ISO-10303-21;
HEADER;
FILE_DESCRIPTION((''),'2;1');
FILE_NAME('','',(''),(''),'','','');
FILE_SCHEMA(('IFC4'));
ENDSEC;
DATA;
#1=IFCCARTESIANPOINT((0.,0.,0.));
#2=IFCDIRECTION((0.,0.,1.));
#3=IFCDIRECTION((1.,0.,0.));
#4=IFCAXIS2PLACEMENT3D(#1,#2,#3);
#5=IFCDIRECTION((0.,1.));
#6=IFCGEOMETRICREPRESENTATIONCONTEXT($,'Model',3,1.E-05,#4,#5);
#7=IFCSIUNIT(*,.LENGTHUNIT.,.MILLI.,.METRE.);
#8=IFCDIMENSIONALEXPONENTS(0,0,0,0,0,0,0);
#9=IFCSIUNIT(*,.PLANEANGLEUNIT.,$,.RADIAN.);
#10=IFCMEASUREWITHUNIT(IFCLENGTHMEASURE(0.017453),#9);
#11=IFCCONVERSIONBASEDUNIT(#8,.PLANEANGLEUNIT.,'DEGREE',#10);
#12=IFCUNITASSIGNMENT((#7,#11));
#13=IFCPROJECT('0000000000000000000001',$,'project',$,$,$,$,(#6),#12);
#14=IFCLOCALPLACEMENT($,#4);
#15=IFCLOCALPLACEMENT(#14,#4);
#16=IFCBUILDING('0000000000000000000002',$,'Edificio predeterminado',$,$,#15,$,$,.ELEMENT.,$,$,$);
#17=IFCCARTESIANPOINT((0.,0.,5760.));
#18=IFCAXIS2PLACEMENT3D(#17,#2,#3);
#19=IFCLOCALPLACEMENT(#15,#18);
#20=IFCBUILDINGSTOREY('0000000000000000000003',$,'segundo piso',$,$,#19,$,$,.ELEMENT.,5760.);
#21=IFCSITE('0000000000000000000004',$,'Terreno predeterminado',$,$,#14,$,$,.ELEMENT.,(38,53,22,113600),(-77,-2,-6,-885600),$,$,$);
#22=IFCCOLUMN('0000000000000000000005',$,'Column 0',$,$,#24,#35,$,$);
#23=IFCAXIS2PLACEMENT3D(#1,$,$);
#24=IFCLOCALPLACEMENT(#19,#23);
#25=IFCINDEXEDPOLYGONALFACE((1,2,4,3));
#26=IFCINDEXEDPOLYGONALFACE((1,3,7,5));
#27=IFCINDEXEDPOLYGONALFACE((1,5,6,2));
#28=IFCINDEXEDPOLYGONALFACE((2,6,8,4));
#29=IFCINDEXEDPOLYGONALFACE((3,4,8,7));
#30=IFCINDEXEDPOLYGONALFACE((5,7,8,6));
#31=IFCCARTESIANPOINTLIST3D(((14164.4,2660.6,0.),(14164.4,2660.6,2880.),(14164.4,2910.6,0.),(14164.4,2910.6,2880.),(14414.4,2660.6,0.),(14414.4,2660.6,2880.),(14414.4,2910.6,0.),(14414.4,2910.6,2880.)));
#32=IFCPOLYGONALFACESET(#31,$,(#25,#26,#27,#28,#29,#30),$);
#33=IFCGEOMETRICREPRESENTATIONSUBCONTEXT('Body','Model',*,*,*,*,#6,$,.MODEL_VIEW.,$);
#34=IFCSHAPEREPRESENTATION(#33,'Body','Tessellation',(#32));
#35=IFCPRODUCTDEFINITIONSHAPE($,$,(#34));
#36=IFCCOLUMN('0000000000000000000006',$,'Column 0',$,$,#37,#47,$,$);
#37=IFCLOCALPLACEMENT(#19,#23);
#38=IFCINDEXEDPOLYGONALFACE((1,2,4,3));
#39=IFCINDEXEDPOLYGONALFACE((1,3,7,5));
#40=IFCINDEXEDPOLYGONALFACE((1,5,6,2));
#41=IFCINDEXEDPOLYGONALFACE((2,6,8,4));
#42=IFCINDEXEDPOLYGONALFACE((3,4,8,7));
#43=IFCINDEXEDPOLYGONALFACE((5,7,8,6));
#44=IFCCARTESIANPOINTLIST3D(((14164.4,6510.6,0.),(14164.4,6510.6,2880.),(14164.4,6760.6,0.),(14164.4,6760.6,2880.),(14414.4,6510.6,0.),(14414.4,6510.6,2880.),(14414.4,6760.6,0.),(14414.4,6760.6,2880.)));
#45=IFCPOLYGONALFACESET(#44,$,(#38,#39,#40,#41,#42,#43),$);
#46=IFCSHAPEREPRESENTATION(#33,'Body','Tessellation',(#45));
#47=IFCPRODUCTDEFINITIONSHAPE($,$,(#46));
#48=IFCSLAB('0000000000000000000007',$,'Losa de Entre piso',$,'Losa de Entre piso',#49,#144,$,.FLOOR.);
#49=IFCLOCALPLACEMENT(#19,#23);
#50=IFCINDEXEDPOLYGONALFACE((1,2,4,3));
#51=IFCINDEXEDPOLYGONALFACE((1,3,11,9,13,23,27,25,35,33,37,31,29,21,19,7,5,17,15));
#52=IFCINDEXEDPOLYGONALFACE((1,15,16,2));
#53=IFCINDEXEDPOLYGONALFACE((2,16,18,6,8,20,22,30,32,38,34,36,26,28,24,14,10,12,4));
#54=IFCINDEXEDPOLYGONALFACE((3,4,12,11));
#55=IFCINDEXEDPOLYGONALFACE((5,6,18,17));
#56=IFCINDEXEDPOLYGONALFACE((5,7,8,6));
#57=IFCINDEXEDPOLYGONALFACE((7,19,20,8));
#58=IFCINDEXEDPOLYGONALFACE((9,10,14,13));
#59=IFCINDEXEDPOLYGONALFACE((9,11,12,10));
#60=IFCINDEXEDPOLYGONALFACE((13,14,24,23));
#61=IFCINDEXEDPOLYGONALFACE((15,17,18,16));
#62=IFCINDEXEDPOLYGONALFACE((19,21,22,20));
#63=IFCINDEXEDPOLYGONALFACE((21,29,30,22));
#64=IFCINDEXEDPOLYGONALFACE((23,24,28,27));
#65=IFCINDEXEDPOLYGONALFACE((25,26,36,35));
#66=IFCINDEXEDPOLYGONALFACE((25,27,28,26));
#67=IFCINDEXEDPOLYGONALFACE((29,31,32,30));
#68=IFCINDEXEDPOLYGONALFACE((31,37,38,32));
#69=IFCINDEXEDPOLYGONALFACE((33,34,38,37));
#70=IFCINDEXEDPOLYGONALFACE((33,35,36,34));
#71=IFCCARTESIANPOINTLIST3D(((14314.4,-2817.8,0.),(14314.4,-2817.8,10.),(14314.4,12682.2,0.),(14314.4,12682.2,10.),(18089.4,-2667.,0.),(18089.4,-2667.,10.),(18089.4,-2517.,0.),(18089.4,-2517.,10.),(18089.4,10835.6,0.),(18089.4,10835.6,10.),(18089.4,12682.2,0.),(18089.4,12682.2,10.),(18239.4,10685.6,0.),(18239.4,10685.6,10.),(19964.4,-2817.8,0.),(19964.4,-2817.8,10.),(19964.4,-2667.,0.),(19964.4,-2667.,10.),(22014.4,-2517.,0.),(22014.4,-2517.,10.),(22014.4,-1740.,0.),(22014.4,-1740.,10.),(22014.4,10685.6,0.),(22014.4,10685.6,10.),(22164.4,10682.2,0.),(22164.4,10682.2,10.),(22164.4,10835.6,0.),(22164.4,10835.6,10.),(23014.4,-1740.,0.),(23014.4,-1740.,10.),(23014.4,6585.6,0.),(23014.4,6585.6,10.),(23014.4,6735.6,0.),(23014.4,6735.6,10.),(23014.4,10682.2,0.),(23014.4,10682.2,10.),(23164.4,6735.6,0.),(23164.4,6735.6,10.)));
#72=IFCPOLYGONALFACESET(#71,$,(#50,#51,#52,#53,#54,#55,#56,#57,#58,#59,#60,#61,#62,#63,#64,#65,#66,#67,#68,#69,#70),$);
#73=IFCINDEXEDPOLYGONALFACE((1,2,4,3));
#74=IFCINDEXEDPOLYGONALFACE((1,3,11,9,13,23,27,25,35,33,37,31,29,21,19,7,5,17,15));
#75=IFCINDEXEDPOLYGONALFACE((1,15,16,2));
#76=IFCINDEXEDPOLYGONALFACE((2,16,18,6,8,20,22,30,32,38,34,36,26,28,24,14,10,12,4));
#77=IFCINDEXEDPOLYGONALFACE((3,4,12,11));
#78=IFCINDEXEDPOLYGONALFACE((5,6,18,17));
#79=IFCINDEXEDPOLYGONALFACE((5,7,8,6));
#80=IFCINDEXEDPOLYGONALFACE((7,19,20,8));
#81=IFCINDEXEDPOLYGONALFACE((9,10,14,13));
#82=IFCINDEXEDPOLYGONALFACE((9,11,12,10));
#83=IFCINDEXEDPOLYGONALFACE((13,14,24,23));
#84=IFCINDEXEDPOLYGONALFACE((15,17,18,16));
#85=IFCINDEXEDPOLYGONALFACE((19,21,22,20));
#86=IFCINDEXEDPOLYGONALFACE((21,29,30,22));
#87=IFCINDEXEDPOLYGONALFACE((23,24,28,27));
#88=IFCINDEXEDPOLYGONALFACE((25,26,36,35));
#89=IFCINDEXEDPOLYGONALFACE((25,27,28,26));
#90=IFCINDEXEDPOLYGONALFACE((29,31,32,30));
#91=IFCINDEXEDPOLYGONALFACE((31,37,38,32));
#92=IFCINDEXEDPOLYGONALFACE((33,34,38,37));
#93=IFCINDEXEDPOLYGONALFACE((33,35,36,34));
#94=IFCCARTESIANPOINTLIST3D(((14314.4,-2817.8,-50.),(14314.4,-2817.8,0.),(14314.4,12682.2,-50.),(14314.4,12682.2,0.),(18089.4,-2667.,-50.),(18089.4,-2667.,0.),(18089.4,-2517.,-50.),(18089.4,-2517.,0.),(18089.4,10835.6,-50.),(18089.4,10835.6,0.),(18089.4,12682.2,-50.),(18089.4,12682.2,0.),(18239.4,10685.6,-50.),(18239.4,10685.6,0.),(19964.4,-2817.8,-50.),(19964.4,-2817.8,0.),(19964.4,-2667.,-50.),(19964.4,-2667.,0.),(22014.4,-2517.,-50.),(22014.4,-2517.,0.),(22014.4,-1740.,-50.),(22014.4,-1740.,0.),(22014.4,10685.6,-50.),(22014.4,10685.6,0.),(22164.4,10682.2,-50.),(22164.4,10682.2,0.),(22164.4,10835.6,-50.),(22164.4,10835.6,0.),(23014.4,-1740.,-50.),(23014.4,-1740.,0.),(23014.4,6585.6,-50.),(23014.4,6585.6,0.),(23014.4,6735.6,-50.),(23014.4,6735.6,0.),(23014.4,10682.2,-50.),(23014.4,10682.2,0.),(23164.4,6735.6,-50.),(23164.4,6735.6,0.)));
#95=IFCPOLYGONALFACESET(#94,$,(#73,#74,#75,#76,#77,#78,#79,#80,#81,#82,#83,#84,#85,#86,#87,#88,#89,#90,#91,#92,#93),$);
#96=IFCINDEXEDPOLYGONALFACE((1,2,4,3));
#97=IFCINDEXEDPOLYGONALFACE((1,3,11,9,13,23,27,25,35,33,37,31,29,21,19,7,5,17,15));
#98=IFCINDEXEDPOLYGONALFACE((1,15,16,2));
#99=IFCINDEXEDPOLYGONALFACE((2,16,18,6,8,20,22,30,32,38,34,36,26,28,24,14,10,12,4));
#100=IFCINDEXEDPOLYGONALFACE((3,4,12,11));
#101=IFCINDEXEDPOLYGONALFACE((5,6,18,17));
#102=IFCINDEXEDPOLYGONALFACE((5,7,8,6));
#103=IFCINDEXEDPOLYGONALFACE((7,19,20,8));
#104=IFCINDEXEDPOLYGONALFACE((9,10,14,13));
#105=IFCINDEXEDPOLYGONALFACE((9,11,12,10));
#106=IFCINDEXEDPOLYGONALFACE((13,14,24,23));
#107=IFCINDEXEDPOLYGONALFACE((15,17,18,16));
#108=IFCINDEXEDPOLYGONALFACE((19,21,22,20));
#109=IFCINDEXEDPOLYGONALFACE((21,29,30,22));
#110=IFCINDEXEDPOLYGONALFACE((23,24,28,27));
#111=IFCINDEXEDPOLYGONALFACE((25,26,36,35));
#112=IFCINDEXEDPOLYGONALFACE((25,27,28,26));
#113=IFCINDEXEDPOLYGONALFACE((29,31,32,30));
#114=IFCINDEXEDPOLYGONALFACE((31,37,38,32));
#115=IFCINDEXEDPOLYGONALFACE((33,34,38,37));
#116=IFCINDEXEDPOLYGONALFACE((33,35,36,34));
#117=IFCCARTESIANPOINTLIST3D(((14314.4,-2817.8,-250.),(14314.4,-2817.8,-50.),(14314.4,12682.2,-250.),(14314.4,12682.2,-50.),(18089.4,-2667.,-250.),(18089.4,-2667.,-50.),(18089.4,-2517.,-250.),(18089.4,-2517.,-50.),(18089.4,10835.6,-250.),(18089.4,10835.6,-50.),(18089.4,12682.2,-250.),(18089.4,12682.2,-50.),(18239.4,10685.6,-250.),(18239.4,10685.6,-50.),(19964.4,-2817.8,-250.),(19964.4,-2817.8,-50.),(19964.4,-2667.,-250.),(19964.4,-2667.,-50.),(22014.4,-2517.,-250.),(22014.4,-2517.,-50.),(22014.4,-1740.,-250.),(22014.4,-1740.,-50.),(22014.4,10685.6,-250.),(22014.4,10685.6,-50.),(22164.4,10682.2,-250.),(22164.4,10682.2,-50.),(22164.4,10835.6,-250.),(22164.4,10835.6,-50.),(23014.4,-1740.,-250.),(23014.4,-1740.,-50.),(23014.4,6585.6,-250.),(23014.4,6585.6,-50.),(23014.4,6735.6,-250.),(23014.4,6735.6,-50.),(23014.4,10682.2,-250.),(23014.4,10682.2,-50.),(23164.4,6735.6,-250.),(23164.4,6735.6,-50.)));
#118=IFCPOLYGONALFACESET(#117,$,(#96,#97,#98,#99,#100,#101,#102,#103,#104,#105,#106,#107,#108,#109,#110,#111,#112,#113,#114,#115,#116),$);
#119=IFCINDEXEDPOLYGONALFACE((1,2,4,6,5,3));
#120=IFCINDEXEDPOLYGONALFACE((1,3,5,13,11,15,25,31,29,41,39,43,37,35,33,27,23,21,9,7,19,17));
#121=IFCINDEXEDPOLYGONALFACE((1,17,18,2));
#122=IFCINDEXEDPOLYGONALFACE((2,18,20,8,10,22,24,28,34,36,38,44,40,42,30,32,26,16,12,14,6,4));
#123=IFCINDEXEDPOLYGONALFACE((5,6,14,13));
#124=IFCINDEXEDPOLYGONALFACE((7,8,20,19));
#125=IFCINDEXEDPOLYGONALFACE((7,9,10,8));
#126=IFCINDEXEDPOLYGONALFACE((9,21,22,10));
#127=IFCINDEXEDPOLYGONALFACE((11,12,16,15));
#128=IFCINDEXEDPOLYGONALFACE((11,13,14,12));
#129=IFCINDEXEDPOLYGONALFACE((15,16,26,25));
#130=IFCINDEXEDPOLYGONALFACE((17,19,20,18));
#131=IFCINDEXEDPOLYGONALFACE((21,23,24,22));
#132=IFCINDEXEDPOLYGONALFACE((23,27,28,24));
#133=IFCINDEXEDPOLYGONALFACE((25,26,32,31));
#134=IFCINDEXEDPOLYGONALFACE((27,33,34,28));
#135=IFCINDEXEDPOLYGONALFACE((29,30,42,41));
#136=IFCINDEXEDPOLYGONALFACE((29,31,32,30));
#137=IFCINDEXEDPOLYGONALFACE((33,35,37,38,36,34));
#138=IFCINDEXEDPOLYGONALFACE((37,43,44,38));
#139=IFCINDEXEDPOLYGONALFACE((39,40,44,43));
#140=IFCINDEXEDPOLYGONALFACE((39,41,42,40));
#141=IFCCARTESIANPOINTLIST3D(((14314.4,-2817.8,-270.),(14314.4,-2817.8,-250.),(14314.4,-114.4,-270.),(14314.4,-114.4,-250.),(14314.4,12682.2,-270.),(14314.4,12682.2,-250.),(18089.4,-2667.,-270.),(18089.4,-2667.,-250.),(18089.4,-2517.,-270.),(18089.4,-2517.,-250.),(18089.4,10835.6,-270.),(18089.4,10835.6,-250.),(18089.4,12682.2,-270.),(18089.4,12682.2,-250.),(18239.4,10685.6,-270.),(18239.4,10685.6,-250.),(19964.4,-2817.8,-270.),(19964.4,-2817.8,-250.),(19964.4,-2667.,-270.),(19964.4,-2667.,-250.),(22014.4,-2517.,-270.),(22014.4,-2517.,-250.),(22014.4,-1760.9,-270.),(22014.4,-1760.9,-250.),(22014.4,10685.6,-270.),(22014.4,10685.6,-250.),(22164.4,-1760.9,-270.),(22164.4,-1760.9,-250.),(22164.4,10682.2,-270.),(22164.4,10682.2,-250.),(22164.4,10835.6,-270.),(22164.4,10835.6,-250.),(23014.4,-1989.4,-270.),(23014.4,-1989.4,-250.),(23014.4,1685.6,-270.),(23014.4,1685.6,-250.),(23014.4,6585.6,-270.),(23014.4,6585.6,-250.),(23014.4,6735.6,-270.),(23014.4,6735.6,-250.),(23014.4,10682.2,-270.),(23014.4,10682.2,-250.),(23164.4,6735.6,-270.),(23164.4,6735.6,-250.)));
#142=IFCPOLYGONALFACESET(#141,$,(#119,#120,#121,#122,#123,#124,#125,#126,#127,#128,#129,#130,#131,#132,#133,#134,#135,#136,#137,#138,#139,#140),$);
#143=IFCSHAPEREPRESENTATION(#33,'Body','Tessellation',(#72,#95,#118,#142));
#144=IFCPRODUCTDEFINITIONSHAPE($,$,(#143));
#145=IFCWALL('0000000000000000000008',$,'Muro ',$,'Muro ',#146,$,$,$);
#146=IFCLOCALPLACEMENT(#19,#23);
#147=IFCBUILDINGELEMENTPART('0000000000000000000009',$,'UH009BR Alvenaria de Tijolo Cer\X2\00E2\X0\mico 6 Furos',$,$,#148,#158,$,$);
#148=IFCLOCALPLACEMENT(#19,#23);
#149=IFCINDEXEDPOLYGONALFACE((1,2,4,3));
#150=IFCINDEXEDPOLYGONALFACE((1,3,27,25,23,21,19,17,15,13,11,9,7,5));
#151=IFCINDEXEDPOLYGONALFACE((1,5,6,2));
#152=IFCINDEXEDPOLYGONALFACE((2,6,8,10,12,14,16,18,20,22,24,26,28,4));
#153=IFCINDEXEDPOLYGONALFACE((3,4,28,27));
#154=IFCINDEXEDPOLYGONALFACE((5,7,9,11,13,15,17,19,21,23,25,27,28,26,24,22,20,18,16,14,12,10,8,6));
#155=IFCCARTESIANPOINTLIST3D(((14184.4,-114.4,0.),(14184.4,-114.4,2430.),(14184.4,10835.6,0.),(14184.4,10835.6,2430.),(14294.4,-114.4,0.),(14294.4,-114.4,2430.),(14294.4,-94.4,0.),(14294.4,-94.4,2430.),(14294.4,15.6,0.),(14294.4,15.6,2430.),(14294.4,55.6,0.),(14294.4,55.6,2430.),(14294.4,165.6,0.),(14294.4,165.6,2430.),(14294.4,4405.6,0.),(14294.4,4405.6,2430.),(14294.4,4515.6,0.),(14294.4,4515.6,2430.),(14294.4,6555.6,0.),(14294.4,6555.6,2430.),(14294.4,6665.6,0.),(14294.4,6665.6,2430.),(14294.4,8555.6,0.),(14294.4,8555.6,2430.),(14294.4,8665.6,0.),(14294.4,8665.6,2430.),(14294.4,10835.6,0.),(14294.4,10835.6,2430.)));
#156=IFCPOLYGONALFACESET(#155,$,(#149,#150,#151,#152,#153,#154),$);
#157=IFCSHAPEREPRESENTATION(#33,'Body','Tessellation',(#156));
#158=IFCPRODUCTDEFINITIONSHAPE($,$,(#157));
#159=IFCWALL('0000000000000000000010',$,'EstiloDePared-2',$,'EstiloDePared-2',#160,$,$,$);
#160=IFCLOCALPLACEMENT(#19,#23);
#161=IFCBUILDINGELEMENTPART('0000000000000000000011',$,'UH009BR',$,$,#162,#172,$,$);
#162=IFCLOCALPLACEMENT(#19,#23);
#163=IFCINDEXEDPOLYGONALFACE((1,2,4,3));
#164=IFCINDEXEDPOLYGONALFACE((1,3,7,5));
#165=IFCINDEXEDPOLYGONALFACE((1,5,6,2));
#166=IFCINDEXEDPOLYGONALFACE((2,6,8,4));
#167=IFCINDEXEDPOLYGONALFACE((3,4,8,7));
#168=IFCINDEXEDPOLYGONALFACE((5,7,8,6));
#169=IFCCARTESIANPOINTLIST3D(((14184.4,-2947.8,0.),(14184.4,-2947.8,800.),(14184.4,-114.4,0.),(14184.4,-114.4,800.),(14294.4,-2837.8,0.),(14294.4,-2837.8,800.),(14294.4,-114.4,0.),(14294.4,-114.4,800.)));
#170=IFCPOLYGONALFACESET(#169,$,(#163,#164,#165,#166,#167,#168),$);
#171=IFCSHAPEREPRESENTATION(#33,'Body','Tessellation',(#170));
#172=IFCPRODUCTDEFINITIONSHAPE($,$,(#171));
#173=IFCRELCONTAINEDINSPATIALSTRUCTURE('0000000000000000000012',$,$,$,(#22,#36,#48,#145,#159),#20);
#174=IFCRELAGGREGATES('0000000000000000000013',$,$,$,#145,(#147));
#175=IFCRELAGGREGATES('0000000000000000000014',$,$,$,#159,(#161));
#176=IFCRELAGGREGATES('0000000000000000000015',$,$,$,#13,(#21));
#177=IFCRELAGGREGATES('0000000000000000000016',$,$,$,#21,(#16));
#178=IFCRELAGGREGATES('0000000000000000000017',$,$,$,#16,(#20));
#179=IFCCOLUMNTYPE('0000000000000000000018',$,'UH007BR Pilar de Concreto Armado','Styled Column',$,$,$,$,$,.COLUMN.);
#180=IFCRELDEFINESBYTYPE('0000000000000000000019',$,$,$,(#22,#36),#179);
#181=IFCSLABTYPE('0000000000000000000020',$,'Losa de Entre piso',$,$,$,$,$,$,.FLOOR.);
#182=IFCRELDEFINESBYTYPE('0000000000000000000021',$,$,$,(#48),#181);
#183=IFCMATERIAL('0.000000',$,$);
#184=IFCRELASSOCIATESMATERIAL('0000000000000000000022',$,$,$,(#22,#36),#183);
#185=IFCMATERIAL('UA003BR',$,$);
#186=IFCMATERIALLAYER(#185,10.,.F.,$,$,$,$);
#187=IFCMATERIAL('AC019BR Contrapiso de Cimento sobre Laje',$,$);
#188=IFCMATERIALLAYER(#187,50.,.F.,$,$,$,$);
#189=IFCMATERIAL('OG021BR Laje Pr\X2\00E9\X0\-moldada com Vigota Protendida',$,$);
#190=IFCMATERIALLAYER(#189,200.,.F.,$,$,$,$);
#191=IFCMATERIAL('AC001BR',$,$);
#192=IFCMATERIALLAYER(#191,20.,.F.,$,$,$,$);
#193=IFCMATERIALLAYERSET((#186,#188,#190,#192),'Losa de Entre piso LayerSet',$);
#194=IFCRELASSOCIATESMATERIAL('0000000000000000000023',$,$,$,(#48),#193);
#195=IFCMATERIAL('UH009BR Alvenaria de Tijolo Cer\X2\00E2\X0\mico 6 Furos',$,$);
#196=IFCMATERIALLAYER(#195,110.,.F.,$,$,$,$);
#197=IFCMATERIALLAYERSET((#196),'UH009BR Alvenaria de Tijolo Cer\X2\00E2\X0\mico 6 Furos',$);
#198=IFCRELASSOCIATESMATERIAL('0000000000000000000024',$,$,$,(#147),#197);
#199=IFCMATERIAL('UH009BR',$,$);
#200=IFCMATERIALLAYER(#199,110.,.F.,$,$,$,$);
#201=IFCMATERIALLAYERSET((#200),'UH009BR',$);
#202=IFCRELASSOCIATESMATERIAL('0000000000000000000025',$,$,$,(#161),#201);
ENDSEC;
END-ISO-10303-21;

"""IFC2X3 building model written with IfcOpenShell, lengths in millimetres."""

from ifc_helpers import new_model, entity, si_unit, converted_unit, direction, frame, origin_with_axes, place, context, subcontext, project, spatial, polyline, outline, extrude, material, layer, layer_set, layer_usage, type_object, element, aggregate, save


model = new_model("IFC2X3")

# Units and contexts
model_context = context("Model", 3, precision=1e-05, world=origin_with_axes(), true_north=direction((0.0, 1.0)))
body_context = subcontext(model_context, "Body", "Model", "MODEL_VIEW")
ifc_project = project(units=[si_unit("LENGTHUNIT", "METRE", prefix="MILLI"), converted_unit("PLANEANGLEUNIT", "DEGREE", entity("IfcLengthMeasure", 0.017453), si_unit("PLANEANGLEUNIT", "RADIAN"), dimensions=[0, 0, 0, 0, 0, 0, 0])], contexts=[model_context])

# Site, building, storey
site_placement = place(None, origin_with_axes())
site = spatial("IfcSite", under=ifc_project, at=site_placement, Name="Terreno predeterminado", CompositionType="ELEMENT", RefLatitude=(38, 53, 22, 113600), RefLongitude=(-77, -2, -6, -885600))
building_placement = place(site_placement, origin_with_axes())
building = spatial("IfcBuilding", under=site, at=building_placement, Name="Edificio predeterminado", CompositionType="ELEMENT")
storey_placement = place(building_placement, frame((0.0, 0.0, 5760.0), z_axis=(0.0, 0.0, 1.0), x_axis=(1.0, 0.0, 0.0)))
storey = spatial("IfcBuildingStorey", under=building, at=storey_placement, Name="segundo piso", CompositionType="ELEMENT", Elevation=5760.0)

# Columns
ifc_material_1 = material(Name="0.000000")
column_type = type_object("IfcColumnType", Name="UH007BR Pilar de Concreto Armado", Description="Styled Column", PredefinedType="COLUMN")
for number, where, z_axis, x_axis, name in (
    (1, (14289.4, 2785.6, 0.0), (0.0, 0.0, 1.0), (1.0, 0.0, 0.0), "Column 0"),
    (2, (14289.4, 6635.6, 0.0), (0.0, 0.0, 1.0), (1.0, 0.0, 0.0), "Column 0"),
):
    element("IfcColumn", number, at=place(storey_placement, frame(where, z_axis=z_axis, x_axis=x_axis)), inside=storey, type_object=column_type, material=ifc_material_1, Name=name, context=body_context, shape_type="SweptSolid", body=[
        extrude(outline(polyline([(-125.0, -125.0), (125.0, -125.0), (125.0, 125.0), (-125.0, 125.0), (-125.0, -125.0)])), origin_with_axes(), (0.0, 0.0, 1.0), 2880.0),
    ])

# Slab
ifc_material_2 = material(Name="UA003BR")
ifc_layer_1 = layer(ifc_material_2, 10.0, ventilated=False)
ifc_material_3 = material(Name="AC019BR Contrapiso de Cimento sobre Laje")
ifc_layer_2 = layer(ifc_material_3, 50.0, ventilated=False)
ifc_material_4 = material(Name="OG021BR Laje Pré-moldada com Vigota Protendida")
ifc_layer_3 = layer(ifc_material_4, 200.0, ventilated=False)
ifc_material_5 = material(Name="AC001BR")
ifc_layer_4 = layer(ifc_material_5, 20.0, ventilated=False)
ifc_layer_set_1 = layer_set([ifc_layer_1, ifc_layer_2, ifc_layer_3, ifc_layer_4], Name="Losa de Entre piso LayerSet")
ifc_layer_usage_1 = layer_usage(ifc_layer_set_1, "AXIS3", "POSITIVE", 0.0)
slab_type = type_object("IfcSlabType", Name="Losa de Entre piso", PredefinedType="FLOOR")
slab_placement = place(storey_placement, frame((0.0, 0.0, -5760.0), z_axis=(0.0, 0.0, 1.0), x_axis=(1.0, 0.0, 0.0)))
element("IfcSlab", 3, at=slab_placement, inside=storey, type_object=slab_type, material=ifc_layer_usage_1, Name="Losa de Entre piso", ObjectType="Losa de Entre piso", PredefinedType="FLOOR", context=body_context, shape_type="SweptSolid", body=[
    extrude(outline(polyline([(0.0, -777.0), (-1000.0, -777.0), (-1000.0, -9102.6), (-1150.0, -9252.6), (-1000.0, -9252.6), (-1000.0, -13199.1), (-150.0, -13199.1), (-150.0, -13352.6), (0.0, -13202.6), (3775.0, -13202.6), (3925.0, -13352.6), (3925.0, -15199.1), (7700.0, -15199.1), (7700.0, 300.9), (2050.0, 300.9), (2050.0, 150.0), (3925.0, 150.0), (3925.0, 0.0), (0.0, 0.0), (0.0, -777.0)])), frame((22014.4, -2517.0, 5760.0), z_axis=(0.0, 0.0, 1.0), x_axis=(-1.0, 0.0, 0.0)), (0.0, 0.0, 1.0), 10.0),
    extrude(outline(polyline([(0.0, -777.0), (-1000.0, -777.0), (-1000.0, -9102.6), (-1150.0, -9252.6), (-1000.0, -9252.6), (-1000.0, -13199.1), (-150.0, -13199.1), (-150.0, -13352.6), (0.0, -13202.6), (3775.0, -13202.6), (3925.0, -13352.6), (3925.0, -15199.1), (7700.0, -15199.1), (7700.0, 300.9), (2050.0, 300.9), (2050.0, 150.0), (3925.0, 150.0), (3925.0, 0.0), (0.0, 0.0), (0.0, -777.0)])), frame((22014.4, -2517.0, 5710.0), z_axis=(0.0, 0.0, 1.0), x_axis=(-1.0, 0.0, 0.0)), (0.0, 0.0, 1.0), 50.0),
    extrude(outline(polyline([(0.0, -777.0), (-1000.0, -777.0), (-1000.0, -9102.6), (-1150.0, -9252.6), (-1000.0, -9252.6), (-1000.0, -13199.1), (-150.0, -13199.1), (-150.0, -13352.6), (0.0, -13202.6), (3775.0, -13202.6), (3925.0, -13352.6), (3925.0, -15199.1), (7700.0, -15199.1), (7700.0, 300.9), (2050.0, 300.9), (2050.0, 150.0), (3925.0, 150.0), (3925.0, 0.0), (0.0, 0.0), (0.0, -777.0)])), frame((22014.4, -2517.0, 5510.0), z_axis=(0.0, 0.0, 1.0), x_axis=(-1.0, 0.0, 0.0)), (0.0, 0.0, 1.0), 200.0),
    extrude(outline(polyline([(-1305.7, 1305.7), (-3975.1, -1363.6), (5073.5, -10412.1), (6985.1, -12323.8), (10980.3, -8328.6), (10873.6, -8221.9), (9547.8, -9547.8), (9441.7, -9441.7), (12217.1, -6666.3), (11682.5, -6131.7), (11788.6, -6025.7), (12551.1, -5586.1), (9952.5, -2987.5), (6487.7, 477.3), (6487.7, 689.4), (6381.6, 583.4), (3591.0, 3374.0), (2990.0, 2773.0), (2881.5, 2881.5), (2881.5, 2669.3), (212.1, 0.0), (0.0, 0.0), (-1305.7, 1305.7)])), frame((18089.4, 10835.6, 5490.0), z_axis=(0.0, 0.0, 1.0), x_axis=(0.707107, -0.707107, 0.0)), (0.0, 0.0, 1.0), 20.0),
])

# Walls, building element parts
wall_1_placement = place(storey_placement, frame((14239.4, 10835.6, 0.0), z_axis=(0.0, 0.0, 1.0), x_axis=(0.0, -1.0, 0.0)))
wall_1 = element("IfcWall", 4, at=wall_1_placement, inside=storey, Name="Muro ", ObjectType="Muro ")
ifc_material_6 = material(Name="UH009BR Alvenaria de Tijolo Cerâmico 6 Furos")
ifc_layer_5 = layer(ifc_material_6, 110.0, ventilated=False)
ifc_layer_set_2 = layer_set([ifc_layer_5], Name="UH009BR Alvenaria de Tijolo Cerâmico 6 Furos")
ifc_layer_usage_2 = layer_usage(ifc_layer_set_2, "AXIS2", "NEGATIVE", -55.0)
building_element_part_1_placement = place(wall_1_placement, origin_with_axes())
building_element_part_1 = element("IfcBuildingElementPart", 5, at=building_element_part_1_placement, material=ifc_layer_usage_2, Name="UH009BR Alvenaria de Tijolo Cerâmico 6 Furos", context=body_context, shape_type="SweptSolid", body=[
    extrude(outline(polyline([(4280.0, 55.0), (6320.0, 55.0), (6430.0, 55.0), (10670.0, 55.0), (10780.0, 55.0), (10820.0, 55.0), (10930.0, 55.0), (10950.0, 55.0), (10950.0, -55.0), (0.0, -55.0), (0.0, 55.0), (2170.0, 55.0), (2280.0, 55.0), (4170.0, 55.0), (4280.0, 55.0)])), origin_with_axes(), (0.0, 0.0, 1.0), 2430.0),
])
aggregate(wall_1, [building_element_part_1])
wall_2_placement = place(storey_placement, frame((14239.4, -2892.8, 0.0), z_axis=(0.0, 0.0, 1.0), x_axis=(0.0, 1.0, 0.0)))
wall_2 = element("IfcWall", 6, at=wall_2_placement, inside=storey, Name="EstiloDePared-2", ObjectType="EstiloDePared-2")
ifc_material_7 = material(Name="UH009BR")
ifc_layer_6 = layer(ifc_material_7, 110.0, ventilated=False)
ifc_layer_set_3 = layer_set([ifc_layer_6], Name="UH009BR")
ifc_layer_usage_3 = layer_usage(ifc_layer_set_3, "AXIS2", "NEGATIVE", -55.0)
building_element_part_2_placement = place(wall_2_placement, origin_with_axes())
building_element_part_2 = element("IfcBuildingElementPart", 7, at=building_element_part_2_placement, material=ifc_layer_usage_3, Name="UH009BR", context=body_context, shape_type="SweptSolid", body=[
    extrude(outline(polyline([(2778.4, 55.0), (2778.4, -55.0), (55.0, -55.0), (-55.0, 55.0), (2778.4, 55.0)])), origin_with_axes(), (0.0, 0.0, 1.0), 800.0),
])
aggregate(wall_2, [building_element_part_2])

save(model, "model.ifc")
